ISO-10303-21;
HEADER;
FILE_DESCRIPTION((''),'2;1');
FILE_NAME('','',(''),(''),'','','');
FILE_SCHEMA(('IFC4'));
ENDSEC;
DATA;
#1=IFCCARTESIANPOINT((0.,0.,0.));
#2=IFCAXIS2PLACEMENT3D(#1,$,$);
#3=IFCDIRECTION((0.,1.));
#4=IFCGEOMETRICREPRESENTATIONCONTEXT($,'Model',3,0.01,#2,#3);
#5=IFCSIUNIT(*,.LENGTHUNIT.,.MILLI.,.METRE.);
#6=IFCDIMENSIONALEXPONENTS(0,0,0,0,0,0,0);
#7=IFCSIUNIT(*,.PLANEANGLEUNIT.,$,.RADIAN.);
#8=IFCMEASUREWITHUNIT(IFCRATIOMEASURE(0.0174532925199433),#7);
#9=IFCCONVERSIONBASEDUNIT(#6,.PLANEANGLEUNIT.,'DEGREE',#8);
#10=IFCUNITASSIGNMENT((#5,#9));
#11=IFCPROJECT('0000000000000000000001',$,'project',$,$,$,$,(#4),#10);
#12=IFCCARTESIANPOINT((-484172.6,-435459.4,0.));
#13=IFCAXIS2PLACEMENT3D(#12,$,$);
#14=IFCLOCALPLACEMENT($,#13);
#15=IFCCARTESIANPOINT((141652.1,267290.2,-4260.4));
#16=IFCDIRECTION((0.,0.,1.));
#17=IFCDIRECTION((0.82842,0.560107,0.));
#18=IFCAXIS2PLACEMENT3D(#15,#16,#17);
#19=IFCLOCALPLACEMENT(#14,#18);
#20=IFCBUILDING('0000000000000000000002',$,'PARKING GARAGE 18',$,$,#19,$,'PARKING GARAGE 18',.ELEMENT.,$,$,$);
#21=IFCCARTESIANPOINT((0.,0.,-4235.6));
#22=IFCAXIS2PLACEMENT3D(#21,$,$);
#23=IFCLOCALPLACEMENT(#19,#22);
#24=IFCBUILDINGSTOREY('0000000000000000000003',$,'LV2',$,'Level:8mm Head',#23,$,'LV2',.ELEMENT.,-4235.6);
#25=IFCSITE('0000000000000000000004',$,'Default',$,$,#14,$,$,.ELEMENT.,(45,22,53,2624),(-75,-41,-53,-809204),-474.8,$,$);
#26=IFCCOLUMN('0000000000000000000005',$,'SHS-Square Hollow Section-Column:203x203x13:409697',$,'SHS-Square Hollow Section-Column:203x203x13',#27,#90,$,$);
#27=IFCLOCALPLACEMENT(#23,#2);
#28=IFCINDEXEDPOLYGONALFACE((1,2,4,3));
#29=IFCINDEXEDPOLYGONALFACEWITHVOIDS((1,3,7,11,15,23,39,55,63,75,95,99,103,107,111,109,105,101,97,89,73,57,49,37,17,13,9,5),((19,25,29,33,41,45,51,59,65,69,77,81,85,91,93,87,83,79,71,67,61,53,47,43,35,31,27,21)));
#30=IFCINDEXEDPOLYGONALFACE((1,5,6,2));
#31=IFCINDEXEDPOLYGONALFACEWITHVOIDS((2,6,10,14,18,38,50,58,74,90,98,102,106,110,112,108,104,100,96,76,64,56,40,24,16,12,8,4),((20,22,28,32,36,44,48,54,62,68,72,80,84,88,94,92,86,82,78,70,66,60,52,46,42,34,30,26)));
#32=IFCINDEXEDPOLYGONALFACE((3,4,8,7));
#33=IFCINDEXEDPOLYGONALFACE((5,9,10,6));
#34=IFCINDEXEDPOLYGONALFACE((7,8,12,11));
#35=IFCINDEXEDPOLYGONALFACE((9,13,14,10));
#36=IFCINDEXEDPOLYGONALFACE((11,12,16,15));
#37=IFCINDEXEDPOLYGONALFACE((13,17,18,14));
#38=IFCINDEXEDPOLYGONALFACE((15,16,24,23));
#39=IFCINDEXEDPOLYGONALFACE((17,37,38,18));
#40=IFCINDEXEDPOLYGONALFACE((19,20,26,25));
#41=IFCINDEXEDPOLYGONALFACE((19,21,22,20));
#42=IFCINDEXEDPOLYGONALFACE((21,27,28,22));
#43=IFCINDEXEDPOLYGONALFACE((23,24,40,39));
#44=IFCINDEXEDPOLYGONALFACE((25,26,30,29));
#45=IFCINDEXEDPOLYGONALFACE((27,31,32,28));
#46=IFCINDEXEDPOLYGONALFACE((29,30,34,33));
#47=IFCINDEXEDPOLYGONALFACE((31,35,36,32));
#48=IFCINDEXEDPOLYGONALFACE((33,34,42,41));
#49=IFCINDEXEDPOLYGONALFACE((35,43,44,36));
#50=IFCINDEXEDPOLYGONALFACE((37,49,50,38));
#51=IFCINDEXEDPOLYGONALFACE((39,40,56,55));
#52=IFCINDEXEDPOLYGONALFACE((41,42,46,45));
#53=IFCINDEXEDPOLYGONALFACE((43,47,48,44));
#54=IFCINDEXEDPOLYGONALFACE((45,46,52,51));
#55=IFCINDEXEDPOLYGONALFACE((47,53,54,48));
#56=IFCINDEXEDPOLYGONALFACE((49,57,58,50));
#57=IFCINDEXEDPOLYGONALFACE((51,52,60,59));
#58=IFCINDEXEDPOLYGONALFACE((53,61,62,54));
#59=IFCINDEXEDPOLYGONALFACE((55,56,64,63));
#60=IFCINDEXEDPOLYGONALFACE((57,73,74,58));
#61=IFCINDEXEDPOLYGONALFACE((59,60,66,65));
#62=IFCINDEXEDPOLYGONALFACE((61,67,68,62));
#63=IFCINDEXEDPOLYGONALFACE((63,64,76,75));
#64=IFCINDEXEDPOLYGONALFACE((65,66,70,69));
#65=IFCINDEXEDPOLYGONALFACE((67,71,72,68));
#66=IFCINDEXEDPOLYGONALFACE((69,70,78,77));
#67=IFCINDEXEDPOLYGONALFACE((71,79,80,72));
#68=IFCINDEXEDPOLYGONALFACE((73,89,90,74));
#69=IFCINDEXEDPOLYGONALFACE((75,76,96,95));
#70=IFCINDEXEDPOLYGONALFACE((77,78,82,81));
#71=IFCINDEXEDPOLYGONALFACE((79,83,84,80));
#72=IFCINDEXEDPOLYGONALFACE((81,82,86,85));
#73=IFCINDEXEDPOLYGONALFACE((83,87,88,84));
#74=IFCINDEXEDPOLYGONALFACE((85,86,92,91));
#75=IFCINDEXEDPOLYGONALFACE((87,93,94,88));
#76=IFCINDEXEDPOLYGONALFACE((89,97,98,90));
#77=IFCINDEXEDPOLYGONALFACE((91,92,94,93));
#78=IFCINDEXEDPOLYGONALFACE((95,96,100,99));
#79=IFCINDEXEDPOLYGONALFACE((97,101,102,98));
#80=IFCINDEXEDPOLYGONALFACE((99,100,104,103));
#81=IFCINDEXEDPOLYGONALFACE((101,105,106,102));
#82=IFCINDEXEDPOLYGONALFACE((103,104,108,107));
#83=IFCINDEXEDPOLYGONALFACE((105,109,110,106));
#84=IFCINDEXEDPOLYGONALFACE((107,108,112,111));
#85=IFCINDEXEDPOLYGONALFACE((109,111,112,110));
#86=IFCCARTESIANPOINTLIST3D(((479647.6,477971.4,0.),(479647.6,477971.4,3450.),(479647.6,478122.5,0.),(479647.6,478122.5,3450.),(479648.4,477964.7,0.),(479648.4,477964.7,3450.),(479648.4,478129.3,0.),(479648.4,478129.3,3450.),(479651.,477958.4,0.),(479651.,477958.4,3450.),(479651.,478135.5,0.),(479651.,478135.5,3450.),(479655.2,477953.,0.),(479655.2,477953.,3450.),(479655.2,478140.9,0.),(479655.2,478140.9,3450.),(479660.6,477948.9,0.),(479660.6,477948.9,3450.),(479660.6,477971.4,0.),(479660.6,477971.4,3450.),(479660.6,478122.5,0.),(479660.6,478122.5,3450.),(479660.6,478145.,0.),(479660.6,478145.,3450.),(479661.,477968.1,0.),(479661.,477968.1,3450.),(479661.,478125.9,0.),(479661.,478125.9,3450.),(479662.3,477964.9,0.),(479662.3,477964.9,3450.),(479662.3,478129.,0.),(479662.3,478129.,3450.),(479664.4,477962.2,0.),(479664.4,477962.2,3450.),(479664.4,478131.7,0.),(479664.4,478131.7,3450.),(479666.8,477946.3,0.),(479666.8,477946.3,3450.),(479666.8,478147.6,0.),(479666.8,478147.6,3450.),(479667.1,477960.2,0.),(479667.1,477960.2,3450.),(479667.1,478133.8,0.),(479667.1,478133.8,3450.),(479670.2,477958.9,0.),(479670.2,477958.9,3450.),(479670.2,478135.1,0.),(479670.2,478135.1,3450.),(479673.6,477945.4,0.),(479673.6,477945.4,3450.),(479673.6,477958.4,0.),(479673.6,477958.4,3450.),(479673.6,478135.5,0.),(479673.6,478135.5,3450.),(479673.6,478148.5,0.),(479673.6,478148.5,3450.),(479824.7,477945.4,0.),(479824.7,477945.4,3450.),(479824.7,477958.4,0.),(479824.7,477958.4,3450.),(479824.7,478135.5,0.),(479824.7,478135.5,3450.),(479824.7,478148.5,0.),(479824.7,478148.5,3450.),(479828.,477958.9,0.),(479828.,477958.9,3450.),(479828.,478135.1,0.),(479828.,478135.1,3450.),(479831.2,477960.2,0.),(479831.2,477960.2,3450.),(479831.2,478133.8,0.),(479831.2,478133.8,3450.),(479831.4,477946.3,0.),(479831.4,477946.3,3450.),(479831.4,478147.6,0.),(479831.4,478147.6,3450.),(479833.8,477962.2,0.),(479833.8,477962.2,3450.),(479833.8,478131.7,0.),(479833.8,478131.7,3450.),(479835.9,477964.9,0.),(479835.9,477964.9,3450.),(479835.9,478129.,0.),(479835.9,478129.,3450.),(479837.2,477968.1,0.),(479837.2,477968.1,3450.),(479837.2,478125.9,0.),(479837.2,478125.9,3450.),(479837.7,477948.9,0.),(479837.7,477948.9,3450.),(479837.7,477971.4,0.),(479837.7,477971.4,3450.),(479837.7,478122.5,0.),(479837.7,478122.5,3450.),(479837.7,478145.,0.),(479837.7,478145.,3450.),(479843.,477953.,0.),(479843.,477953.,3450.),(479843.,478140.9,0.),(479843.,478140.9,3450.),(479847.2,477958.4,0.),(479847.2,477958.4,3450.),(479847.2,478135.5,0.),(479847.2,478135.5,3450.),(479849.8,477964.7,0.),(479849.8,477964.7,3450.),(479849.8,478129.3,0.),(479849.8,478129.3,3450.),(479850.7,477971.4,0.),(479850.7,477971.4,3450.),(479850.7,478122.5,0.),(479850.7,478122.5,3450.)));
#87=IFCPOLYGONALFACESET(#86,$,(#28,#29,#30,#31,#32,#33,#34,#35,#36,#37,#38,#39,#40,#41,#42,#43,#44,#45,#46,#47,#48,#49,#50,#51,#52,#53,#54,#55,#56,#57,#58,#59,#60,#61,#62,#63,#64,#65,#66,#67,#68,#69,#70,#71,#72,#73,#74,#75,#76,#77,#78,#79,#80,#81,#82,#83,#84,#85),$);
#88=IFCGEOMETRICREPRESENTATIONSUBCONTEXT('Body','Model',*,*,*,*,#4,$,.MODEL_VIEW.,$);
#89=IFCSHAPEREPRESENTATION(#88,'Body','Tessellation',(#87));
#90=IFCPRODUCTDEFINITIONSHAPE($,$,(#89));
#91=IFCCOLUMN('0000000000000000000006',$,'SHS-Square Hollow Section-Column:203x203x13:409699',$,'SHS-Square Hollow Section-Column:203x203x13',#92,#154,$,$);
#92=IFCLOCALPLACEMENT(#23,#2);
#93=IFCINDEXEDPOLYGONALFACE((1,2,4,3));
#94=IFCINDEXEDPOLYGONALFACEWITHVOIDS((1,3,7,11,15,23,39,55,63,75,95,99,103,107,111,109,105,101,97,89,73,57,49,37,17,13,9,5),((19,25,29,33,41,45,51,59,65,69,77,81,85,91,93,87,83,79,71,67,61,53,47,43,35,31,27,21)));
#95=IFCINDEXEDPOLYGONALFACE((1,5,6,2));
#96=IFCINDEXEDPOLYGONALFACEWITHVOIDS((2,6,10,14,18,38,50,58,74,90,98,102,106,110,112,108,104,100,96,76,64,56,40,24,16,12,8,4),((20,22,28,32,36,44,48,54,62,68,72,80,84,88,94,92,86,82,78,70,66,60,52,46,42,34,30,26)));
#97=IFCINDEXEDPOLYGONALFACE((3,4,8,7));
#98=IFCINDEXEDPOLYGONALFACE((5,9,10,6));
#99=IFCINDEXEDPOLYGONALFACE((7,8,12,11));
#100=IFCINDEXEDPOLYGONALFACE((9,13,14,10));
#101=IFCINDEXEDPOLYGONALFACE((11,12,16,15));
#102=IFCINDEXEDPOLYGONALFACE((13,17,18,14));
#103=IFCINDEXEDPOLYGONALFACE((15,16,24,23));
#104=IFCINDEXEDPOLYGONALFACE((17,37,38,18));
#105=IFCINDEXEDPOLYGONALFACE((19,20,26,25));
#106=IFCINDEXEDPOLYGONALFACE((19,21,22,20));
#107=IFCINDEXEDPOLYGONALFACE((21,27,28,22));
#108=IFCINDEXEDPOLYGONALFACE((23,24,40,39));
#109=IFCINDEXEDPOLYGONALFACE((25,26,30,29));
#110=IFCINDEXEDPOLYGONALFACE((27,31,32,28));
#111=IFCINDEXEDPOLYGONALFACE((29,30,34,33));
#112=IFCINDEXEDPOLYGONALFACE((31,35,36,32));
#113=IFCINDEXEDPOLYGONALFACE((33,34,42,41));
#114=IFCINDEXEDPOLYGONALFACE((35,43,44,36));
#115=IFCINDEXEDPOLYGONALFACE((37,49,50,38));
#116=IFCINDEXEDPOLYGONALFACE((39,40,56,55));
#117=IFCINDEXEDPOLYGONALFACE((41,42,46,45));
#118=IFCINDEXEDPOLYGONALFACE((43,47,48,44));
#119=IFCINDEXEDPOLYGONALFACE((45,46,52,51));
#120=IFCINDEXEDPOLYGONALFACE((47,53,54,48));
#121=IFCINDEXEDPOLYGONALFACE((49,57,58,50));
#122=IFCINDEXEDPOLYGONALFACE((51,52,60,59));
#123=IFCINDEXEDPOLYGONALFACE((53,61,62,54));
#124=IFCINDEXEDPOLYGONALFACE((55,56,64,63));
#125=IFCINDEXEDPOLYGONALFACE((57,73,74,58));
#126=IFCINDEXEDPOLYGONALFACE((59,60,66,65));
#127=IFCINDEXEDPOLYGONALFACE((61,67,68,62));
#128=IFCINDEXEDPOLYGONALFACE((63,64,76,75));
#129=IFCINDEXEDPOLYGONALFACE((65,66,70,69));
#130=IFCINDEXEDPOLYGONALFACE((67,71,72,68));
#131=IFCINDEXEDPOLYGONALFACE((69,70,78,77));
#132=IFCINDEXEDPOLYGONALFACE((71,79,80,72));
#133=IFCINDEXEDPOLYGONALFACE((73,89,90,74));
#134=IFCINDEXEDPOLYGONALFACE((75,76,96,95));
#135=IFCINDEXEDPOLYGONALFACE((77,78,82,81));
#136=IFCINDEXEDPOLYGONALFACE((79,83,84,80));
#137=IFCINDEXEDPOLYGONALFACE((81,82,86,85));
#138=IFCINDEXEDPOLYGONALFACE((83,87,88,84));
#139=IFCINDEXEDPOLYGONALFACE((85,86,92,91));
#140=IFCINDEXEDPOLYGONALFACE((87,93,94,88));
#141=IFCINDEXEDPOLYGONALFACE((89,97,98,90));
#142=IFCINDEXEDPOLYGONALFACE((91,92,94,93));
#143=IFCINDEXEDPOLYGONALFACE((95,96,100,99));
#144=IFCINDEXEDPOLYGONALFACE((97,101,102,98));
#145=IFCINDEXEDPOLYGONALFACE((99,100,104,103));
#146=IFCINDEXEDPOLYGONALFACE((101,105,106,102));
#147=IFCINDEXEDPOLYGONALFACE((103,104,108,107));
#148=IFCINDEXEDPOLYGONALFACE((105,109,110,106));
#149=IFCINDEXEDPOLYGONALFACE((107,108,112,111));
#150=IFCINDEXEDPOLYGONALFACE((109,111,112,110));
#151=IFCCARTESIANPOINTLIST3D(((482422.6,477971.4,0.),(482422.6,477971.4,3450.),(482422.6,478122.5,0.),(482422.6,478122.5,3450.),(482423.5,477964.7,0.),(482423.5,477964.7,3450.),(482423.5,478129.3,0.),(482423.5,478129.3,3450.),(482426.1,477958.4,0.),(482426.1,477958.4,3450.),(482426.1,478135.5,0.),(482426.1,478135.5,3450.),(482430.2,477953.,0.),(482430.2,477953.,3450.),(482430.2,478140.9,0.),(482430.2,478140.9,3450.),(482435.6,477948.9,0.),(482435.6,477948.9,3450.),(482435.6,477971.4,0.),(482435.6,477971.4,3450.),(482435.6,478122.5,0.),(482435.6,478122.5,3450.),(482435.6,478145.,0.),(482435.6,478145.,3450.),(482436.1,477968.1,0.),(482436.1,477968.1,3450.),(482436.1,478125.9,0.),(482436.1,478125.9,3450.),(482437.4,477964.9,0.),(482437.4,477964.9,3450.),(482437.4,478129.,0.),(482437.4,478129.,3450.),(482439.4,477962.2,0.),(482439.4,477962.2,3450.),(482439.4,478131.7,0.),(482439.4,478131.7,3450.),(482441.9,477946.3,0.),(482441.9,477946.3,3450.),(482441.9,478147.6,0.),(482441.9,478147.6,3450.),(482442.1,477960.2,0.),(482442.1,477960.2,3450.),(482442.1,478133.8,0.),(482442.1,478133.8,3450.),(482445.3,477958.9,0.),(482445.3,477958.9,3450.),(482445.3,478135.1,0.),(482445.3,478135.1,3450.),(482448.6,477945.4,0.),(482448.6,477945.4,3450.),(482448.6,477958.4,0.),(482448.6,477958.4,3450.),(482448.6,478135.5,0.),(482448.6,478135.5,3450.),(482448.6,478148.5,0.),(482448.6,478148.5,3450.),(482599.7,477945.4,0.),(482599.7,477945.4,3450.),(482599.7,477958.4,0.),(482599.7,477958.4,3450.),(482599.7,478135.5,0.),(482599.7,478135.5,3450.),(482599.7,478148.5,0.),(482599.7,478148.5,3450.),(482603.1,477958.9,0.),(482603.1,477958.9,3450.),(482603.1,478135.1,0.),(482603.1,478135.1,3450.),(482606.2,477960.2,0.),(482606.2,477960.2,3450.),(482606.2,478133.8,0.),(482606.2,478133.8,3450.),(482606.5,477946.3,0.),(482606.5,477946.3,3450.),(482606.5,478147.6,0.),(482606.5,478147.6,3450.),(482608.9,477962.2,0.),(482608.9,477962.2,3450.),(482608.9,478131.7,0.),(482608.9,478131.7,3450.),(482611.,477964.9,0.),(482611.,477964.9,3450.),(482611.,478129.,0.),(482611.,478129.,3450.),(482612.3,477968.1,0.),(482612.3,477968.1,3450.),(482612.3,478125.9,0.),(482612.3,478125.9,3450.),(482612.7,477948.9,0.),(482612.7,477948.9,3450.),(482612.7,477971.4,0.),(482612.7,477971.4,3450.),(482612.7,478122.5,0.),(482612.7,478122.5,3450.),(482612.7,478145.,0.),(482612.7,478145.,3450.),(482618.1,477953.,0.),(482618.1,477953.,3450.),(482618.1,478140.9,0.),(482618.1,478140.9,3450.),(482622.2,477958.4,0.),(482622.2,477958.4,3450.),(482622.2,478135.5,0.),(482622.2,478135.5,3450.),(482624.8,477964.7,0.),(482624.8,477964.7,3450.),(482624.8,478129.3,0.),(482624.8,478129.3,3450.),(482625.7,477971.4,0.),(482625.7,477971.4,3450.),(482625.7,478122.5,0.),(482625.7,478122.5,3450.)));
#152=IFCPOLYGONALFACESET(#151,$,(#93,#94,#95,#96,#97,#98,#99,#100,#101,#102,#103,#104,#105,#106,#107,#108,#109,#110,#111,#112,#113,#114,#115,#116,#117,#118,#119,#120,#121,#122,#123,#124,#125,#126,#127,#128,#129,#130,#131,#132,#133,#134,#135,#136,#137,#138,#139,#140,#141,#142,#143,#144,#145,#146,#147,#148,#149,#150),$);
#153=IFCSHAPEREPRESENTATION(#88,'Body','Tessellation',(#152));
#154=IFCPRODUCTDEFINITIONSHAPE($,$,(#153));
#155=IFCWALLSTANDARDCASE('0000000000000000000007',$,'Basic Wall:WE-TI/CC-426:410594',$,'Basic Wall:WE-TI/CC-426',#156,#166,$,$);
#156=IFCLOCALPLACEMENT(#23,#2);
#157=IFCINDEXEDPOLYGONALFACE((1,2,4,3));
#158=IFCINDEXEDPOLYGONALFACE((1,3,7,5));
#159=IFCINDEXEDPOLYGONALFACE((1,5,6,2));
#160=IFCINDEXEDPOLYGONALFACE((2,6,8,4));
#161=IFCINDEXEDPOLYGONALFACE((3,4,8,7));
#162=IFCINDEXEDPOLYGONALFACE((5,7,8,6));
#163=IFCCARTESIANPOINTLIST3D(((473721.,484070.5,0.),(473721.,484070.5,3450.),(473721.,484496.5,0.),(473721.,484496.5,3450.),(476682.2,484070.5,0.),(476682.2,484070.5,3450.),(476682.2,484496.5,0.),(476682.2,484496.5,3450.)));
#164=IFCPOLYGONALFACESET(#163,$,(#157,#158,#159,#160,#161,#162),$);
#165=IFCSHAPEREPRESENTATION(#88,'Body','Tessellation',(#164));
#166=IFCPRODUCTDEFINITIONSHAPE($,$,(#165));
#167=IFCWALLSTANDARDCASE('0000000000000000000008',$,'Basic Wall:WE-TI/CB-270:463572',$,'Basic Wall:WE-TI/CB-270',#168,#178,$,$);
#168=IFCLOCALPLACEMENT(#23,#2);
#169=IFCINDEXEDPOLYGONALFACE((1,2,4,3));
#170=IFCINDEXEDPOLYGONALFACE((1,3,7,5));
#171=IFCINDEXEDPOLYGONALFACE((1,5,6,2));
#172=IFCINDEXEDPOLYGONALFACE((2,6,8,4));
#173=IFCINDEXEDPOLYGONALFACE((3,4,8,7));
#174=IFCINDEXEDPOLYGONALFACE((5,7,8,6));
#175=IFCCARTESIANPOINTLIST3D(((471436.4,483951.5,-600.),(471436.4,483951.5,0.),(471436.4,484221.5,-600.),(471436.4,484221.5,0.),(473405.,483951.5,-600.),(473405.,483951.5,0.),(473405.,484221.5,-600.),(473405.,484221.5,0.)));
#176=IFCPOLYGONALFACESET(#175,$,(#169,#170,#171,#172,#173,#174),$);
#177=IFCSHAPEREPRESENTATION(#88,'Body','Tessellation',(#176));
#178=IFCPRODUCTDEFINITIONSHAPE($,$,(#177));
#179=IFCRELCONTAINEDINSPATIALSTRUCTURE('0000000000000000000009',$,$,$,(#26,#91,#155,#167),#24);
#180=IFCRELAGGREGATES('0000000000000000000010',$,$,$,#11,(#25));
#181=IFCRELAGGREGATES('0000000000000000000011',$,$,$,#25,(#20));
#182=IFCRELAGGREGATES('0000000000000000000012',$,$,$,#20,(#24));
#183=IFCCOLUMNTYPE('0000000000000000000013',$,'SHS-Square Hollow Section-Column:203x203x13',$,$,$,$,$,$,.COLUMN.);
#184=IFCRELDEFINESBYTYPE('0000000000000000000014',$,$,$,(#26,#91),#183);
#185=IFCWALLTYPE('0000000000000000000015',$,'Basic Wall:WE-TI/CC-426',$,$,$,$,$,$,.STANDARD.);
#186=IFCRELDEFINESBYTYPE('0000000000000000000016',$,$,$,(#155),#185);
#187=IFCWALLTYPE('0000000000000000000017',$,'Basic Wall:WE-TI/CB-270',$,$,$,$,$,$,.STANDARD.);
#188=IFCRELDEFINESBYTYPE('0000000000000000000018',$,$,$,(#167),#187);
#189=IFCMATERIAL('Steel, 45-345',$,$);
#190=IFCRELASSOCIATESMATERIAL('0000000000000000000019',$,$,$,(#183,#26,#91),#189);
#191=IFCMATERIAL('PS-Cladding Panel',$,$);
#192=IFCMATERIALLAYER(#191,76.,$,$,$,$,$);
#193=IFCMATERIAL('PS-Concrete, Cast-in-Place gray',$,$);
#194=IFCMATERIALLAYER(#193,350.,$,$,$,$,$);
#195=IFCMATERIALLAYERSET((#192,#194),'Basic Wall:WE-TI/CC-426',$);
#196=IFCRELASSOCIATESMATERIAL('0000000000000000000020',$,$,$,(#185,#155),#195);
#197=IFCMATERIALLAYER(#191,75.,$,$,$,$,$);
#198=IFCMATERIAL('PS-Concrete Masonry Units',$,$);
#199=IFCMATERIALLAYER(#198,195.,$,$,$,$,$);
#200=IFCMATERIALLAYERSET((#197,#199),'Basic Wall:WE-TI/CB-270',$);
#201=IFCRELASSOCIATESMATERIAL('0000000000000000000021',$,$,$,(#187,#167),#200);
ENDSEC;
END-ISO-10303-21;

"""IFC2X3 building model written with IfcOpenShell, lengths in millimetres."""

from ifc_helpers import new_model, entity, si_unit, converted_unit, direction, frame, frame_2d, origin, place, context, subcontext, project, spatial, polyline, circle_curve, parameter, trimmed, segment, composite_curve, rectangle, outline, extrude, source, transform, mapped, material, layer, layer_set, layer_usage, type_object, type_shapes, element, save


model = new_model("IFC2X3")

# Units and contexts
model_context = context("Model", 3, precision=0.01, world=origin(), true_north=direction((0.0, 1.0)))
body_context = subcontext(model_context, "Body", "Model", "MODEL_VIEW")
ifc_project = project(units=[si_unit("LENGTHUNIT", "METRE", prefix="MILLI"), converted_unit("PLANEANGLEUNIT", "DEGREE", entity("IfcRatioMeasure", 0.0174532925199433), si_unit("PLANEANGLEUNIT", "RADIAN"), dimensions=[0, 0, 0, 0, 0, 0, 0])], contexts=[model_context])

# Site, building, storey
site_placement = place(None, frame((-484172.6, -435459.4, 0.0)))
site = spatial("IfcSite", under=ifc_project, at=site_placement, Name="Default", CompositionType="ELEMENT", RefLatitude=(45, 22, 53, 2624), RefLongitude=(-75, -41, -53, -809204), RefElevation=-474.8)
building_placement = place(site_placement, frame((141652.1, 267290.2, -4260.4), z_axis=(0.0, 0.0, 1.0), x_axis=(0.82842, 0.560107, 0.0)))
building = spatial("IfcBuilding", under=site, at=building_placement, Name="PARKING GARAGE 18", LongName="PARKING GARAGE 18", CompositionType="ELEMENT")
storey_placement = place(building_placement, frame((0.0, 0.0, -4235.6)))
storey = spatial("IfcBuildingStorey", under=building, at=storey_placement, Name="LV2", ObjectType="Level:8mm Head", LongName="LV2", CompositionType="ELEMENT", Elevation=-4235.6)

# Columns
ifc_material_1 = material(Name="Steel, 45-345")
column_type = type_object("IfcColumnType", Name="SHS-Square Hollow Section-Column:203x203x13", PredefinedType="COLUMN", material=ifc_material_1)
shared_shape_1 = source(origin(), body_context, "Body", "SweptSolid", [
    extrude(outline(composite_curve([segment(polyline([(-75.6, -101.5), (75.6, -101.5)]), True, "CONTINUOUS"), segment(trimmed(circle_curve(frame_2d((75.6, -75.6), x_axis=(-1.0, 0.0)), 26.0), [parameter(90.0)], [parameter(180.0)], True, "PARAMETER"), True, "CONTINUOUS"), segment(polyline([(101.5, -75.6), (101.5, 75.6)]), True, "CONTINUOUS"), segment(trimmed(circle_curve(frame_2d((75.5, 75.6), x_axis=(-1.0, 0.0)), 26.0), [parameter(180.0)], [parameter(270.0)], True, "PARAMETER"), True, "CONTINUOUS"), segment(polyline([(75.5, 101.6), (-75.5, 101.6)]), True, "CONTINUOUS"), segment(trimmed(circle_curve(frame_2d((-75.5, 75.5), x_axis=(-1.0, 0.0)), 26.0), [parameter(270.0)], [parameter(360.0)], True, "PARAMETER"), True, "CONTINUOUS"), segment(polyline([(-101.5, 75.5), (-101.5, -75.6)]), True, "CONTINUOUS"), segment(trimmed(circle_curve(frame_2d((-75.6, -75.6), x_axis=(-1.0, 0.0)), 26.0), [parameter(360.0)], [parameter(90.0)], True, "PARAMETER"), True, "CONTINUOUS")], self_intersect=False), holes=[composite_curve([segment(trimmed(circle_curve(frame_2d((-75.6, -75.6), x_axis=(-1.0, 0.0)), 13.0), [parameter(0.0)], [parameter(90.0)], True, "PARAMETER"), False, "CONTINUOUS"), segment(polyline([(-88.5, -75.6), (-88.5, 75.6)]), True, "CONTINUOUS"), segment(trimmed(circle_curve(frame_2d((-75.6, 75.6), x_axis=(-1.0, 0.0)), 13.0), [parameter(270.0)], [parameter(0.0)], True, "PARAMETER"), False, "CONTINUOUS"), segment(polyline([(-75.6, 88.6), (75.5, 88.6)]), True, "CONTINUOUS"), segment(trimmed(circle_curve(frame_2d((75.5, 75.5), x_axis=(-1.0, 0.0)), 13.0), [parameter(180.0)], [parameter(270.0)], True, "PARAMETER"), False, "CONTINUOUS"), segment(polyline([(88.6, 75.5), (88.6, -75.5)]), True, "CONTINUOUS"), segment(trimmed(circle_curve(frame_2d((75.6, -75.5), x_axis=(-1.0, 0.0)), 13.0), [parameter(90.0)], [parameter(180.0)], True, "PARAMETER"), False, "CONTINUOUS"), segment(polyline([(75.6, -88.5), (-75.6, -88.5)]), True, "CONTINUOUS")], self_intersect=False)]), frame((0.0, 0.0, -4235.6), z_axis=(0.0, 0.0, 1.0), x_axis=(-1.0, 0.0, 0.0)), (0.0, 0.0, 1.0), 3450.0),
])
type_shapes(column_type, [shared_shape_1])
for number, where, name in (
    (1, (479749.1, 478047.0, 4235.6), "SHS-Square Hollow Section-Column:203x203x13:409697"),
    (2, (482524.2, 478047.0, 4235.6), "SHS-Square Hollow Section-Column:203x203x13:409699"),
):
    element("IfcColumn", number, at=place(storey_placement, frame(where)), inside=storey, type_object=column_type, material=ifc_material_1, Name=name, ObjectType="SHS-Square Hollow Section-Column:203x203x13", context=body_context, shape_type="MappedRepresentation", body=[
        mapped(shared_shape_1, transform((0.0, 0.0, 0.0), scale=1.0)),
    ])

# Walls
ifc_material_2 = material(Name="PS-Cladding Panel")
ifc_layer_1 = layer(ifc_material_2, 76.0)
ifc_material_3 = material(Name="PS-Concrete, Cast-in-Place gray")
ifc_layer_2 = layer(ifc_material_3, 350.0)
ifc_layer_set_1 = layer_set([ifc_layer_1, ifc_layer_2], Name="Basic Wall:WE-TI/CC-426")
ifc_layer_usage_1 = layer_usage(ifc_layer_set_1, "AXIS2", "POSITIVE", -213.0)
wall_type_1 = type_object("IfcWallType", Name="Basic Wall:WE-TI/CC-426", PredefinedType="STANDARD", material=ifc_layer_set_1)
wall_1_placement = place(storey_placement, frame((473721.0, 484283.5, 0.0)))
element("IfcWallStandardCase", 3, at=wall_1_placement, inside=storey, type_object=wall_type_1, material=ifc_layer_usage_1, Name="Basic Wall:WE-TI/CC-426:410594", ObjectType="Basic Wall:WE-TI/CC-426", context=body_context, shape_type="SweptSolid", body=[
    extrude(rectangle(XDim=2961.2, YDim=426.0, at=frame_2d((1480.6, 0.0), x_axis=(-1.0, 0.0))), origin(), (0.0, 0.0, 1.0), 3450.0),
])
ifc_layer_3 = layer(ifc_material_2, 75.0)
ifc_material_4 = material(Name="PS-Concrete Masonry Units")
ifc_layer_4 = layer(ifc_material_4, 195.0)
ifc_layer_set_2 = layer_set([ifc_layer_3, ifc_layer_4], Name="Basic Wall:WE-TI/CB-270")
ifc_layer_usage_2 = layer_usage(ifc_layer_set_2, "AXIS2", "NEGATIVE", 135.0)
wall_type_2 = type_object("IfcWallType", Name="Basic Wall:WE-TI/CB-270", PredefinedType="STANDARD", material=ifc_layer_set_2)
wall_2_placement = place(storey_placement, frame((471436.4, 484086.5, -600.0)))
element("IfcWallStandardCase", 4, at=wall_2_placement, inside=storey, type_object=wall_type_2, material=ifc_layer_usage_2, Name="Basic Wall:WE-TI/CB-270:463572", ObjectType="Basic Wall:WE-TI/CB-270", context=body_context, shape_type="SweptSolid", body=[
    extrude(rectangle(XDim=1968.6, YDim=270.0, at=frame_2d((984.3, 0.0), x_axis=(-1.0, 0.0))), origin(), (0.0, 0.0, 1.0), 600.0),
])

save(model, "model.ifc")
